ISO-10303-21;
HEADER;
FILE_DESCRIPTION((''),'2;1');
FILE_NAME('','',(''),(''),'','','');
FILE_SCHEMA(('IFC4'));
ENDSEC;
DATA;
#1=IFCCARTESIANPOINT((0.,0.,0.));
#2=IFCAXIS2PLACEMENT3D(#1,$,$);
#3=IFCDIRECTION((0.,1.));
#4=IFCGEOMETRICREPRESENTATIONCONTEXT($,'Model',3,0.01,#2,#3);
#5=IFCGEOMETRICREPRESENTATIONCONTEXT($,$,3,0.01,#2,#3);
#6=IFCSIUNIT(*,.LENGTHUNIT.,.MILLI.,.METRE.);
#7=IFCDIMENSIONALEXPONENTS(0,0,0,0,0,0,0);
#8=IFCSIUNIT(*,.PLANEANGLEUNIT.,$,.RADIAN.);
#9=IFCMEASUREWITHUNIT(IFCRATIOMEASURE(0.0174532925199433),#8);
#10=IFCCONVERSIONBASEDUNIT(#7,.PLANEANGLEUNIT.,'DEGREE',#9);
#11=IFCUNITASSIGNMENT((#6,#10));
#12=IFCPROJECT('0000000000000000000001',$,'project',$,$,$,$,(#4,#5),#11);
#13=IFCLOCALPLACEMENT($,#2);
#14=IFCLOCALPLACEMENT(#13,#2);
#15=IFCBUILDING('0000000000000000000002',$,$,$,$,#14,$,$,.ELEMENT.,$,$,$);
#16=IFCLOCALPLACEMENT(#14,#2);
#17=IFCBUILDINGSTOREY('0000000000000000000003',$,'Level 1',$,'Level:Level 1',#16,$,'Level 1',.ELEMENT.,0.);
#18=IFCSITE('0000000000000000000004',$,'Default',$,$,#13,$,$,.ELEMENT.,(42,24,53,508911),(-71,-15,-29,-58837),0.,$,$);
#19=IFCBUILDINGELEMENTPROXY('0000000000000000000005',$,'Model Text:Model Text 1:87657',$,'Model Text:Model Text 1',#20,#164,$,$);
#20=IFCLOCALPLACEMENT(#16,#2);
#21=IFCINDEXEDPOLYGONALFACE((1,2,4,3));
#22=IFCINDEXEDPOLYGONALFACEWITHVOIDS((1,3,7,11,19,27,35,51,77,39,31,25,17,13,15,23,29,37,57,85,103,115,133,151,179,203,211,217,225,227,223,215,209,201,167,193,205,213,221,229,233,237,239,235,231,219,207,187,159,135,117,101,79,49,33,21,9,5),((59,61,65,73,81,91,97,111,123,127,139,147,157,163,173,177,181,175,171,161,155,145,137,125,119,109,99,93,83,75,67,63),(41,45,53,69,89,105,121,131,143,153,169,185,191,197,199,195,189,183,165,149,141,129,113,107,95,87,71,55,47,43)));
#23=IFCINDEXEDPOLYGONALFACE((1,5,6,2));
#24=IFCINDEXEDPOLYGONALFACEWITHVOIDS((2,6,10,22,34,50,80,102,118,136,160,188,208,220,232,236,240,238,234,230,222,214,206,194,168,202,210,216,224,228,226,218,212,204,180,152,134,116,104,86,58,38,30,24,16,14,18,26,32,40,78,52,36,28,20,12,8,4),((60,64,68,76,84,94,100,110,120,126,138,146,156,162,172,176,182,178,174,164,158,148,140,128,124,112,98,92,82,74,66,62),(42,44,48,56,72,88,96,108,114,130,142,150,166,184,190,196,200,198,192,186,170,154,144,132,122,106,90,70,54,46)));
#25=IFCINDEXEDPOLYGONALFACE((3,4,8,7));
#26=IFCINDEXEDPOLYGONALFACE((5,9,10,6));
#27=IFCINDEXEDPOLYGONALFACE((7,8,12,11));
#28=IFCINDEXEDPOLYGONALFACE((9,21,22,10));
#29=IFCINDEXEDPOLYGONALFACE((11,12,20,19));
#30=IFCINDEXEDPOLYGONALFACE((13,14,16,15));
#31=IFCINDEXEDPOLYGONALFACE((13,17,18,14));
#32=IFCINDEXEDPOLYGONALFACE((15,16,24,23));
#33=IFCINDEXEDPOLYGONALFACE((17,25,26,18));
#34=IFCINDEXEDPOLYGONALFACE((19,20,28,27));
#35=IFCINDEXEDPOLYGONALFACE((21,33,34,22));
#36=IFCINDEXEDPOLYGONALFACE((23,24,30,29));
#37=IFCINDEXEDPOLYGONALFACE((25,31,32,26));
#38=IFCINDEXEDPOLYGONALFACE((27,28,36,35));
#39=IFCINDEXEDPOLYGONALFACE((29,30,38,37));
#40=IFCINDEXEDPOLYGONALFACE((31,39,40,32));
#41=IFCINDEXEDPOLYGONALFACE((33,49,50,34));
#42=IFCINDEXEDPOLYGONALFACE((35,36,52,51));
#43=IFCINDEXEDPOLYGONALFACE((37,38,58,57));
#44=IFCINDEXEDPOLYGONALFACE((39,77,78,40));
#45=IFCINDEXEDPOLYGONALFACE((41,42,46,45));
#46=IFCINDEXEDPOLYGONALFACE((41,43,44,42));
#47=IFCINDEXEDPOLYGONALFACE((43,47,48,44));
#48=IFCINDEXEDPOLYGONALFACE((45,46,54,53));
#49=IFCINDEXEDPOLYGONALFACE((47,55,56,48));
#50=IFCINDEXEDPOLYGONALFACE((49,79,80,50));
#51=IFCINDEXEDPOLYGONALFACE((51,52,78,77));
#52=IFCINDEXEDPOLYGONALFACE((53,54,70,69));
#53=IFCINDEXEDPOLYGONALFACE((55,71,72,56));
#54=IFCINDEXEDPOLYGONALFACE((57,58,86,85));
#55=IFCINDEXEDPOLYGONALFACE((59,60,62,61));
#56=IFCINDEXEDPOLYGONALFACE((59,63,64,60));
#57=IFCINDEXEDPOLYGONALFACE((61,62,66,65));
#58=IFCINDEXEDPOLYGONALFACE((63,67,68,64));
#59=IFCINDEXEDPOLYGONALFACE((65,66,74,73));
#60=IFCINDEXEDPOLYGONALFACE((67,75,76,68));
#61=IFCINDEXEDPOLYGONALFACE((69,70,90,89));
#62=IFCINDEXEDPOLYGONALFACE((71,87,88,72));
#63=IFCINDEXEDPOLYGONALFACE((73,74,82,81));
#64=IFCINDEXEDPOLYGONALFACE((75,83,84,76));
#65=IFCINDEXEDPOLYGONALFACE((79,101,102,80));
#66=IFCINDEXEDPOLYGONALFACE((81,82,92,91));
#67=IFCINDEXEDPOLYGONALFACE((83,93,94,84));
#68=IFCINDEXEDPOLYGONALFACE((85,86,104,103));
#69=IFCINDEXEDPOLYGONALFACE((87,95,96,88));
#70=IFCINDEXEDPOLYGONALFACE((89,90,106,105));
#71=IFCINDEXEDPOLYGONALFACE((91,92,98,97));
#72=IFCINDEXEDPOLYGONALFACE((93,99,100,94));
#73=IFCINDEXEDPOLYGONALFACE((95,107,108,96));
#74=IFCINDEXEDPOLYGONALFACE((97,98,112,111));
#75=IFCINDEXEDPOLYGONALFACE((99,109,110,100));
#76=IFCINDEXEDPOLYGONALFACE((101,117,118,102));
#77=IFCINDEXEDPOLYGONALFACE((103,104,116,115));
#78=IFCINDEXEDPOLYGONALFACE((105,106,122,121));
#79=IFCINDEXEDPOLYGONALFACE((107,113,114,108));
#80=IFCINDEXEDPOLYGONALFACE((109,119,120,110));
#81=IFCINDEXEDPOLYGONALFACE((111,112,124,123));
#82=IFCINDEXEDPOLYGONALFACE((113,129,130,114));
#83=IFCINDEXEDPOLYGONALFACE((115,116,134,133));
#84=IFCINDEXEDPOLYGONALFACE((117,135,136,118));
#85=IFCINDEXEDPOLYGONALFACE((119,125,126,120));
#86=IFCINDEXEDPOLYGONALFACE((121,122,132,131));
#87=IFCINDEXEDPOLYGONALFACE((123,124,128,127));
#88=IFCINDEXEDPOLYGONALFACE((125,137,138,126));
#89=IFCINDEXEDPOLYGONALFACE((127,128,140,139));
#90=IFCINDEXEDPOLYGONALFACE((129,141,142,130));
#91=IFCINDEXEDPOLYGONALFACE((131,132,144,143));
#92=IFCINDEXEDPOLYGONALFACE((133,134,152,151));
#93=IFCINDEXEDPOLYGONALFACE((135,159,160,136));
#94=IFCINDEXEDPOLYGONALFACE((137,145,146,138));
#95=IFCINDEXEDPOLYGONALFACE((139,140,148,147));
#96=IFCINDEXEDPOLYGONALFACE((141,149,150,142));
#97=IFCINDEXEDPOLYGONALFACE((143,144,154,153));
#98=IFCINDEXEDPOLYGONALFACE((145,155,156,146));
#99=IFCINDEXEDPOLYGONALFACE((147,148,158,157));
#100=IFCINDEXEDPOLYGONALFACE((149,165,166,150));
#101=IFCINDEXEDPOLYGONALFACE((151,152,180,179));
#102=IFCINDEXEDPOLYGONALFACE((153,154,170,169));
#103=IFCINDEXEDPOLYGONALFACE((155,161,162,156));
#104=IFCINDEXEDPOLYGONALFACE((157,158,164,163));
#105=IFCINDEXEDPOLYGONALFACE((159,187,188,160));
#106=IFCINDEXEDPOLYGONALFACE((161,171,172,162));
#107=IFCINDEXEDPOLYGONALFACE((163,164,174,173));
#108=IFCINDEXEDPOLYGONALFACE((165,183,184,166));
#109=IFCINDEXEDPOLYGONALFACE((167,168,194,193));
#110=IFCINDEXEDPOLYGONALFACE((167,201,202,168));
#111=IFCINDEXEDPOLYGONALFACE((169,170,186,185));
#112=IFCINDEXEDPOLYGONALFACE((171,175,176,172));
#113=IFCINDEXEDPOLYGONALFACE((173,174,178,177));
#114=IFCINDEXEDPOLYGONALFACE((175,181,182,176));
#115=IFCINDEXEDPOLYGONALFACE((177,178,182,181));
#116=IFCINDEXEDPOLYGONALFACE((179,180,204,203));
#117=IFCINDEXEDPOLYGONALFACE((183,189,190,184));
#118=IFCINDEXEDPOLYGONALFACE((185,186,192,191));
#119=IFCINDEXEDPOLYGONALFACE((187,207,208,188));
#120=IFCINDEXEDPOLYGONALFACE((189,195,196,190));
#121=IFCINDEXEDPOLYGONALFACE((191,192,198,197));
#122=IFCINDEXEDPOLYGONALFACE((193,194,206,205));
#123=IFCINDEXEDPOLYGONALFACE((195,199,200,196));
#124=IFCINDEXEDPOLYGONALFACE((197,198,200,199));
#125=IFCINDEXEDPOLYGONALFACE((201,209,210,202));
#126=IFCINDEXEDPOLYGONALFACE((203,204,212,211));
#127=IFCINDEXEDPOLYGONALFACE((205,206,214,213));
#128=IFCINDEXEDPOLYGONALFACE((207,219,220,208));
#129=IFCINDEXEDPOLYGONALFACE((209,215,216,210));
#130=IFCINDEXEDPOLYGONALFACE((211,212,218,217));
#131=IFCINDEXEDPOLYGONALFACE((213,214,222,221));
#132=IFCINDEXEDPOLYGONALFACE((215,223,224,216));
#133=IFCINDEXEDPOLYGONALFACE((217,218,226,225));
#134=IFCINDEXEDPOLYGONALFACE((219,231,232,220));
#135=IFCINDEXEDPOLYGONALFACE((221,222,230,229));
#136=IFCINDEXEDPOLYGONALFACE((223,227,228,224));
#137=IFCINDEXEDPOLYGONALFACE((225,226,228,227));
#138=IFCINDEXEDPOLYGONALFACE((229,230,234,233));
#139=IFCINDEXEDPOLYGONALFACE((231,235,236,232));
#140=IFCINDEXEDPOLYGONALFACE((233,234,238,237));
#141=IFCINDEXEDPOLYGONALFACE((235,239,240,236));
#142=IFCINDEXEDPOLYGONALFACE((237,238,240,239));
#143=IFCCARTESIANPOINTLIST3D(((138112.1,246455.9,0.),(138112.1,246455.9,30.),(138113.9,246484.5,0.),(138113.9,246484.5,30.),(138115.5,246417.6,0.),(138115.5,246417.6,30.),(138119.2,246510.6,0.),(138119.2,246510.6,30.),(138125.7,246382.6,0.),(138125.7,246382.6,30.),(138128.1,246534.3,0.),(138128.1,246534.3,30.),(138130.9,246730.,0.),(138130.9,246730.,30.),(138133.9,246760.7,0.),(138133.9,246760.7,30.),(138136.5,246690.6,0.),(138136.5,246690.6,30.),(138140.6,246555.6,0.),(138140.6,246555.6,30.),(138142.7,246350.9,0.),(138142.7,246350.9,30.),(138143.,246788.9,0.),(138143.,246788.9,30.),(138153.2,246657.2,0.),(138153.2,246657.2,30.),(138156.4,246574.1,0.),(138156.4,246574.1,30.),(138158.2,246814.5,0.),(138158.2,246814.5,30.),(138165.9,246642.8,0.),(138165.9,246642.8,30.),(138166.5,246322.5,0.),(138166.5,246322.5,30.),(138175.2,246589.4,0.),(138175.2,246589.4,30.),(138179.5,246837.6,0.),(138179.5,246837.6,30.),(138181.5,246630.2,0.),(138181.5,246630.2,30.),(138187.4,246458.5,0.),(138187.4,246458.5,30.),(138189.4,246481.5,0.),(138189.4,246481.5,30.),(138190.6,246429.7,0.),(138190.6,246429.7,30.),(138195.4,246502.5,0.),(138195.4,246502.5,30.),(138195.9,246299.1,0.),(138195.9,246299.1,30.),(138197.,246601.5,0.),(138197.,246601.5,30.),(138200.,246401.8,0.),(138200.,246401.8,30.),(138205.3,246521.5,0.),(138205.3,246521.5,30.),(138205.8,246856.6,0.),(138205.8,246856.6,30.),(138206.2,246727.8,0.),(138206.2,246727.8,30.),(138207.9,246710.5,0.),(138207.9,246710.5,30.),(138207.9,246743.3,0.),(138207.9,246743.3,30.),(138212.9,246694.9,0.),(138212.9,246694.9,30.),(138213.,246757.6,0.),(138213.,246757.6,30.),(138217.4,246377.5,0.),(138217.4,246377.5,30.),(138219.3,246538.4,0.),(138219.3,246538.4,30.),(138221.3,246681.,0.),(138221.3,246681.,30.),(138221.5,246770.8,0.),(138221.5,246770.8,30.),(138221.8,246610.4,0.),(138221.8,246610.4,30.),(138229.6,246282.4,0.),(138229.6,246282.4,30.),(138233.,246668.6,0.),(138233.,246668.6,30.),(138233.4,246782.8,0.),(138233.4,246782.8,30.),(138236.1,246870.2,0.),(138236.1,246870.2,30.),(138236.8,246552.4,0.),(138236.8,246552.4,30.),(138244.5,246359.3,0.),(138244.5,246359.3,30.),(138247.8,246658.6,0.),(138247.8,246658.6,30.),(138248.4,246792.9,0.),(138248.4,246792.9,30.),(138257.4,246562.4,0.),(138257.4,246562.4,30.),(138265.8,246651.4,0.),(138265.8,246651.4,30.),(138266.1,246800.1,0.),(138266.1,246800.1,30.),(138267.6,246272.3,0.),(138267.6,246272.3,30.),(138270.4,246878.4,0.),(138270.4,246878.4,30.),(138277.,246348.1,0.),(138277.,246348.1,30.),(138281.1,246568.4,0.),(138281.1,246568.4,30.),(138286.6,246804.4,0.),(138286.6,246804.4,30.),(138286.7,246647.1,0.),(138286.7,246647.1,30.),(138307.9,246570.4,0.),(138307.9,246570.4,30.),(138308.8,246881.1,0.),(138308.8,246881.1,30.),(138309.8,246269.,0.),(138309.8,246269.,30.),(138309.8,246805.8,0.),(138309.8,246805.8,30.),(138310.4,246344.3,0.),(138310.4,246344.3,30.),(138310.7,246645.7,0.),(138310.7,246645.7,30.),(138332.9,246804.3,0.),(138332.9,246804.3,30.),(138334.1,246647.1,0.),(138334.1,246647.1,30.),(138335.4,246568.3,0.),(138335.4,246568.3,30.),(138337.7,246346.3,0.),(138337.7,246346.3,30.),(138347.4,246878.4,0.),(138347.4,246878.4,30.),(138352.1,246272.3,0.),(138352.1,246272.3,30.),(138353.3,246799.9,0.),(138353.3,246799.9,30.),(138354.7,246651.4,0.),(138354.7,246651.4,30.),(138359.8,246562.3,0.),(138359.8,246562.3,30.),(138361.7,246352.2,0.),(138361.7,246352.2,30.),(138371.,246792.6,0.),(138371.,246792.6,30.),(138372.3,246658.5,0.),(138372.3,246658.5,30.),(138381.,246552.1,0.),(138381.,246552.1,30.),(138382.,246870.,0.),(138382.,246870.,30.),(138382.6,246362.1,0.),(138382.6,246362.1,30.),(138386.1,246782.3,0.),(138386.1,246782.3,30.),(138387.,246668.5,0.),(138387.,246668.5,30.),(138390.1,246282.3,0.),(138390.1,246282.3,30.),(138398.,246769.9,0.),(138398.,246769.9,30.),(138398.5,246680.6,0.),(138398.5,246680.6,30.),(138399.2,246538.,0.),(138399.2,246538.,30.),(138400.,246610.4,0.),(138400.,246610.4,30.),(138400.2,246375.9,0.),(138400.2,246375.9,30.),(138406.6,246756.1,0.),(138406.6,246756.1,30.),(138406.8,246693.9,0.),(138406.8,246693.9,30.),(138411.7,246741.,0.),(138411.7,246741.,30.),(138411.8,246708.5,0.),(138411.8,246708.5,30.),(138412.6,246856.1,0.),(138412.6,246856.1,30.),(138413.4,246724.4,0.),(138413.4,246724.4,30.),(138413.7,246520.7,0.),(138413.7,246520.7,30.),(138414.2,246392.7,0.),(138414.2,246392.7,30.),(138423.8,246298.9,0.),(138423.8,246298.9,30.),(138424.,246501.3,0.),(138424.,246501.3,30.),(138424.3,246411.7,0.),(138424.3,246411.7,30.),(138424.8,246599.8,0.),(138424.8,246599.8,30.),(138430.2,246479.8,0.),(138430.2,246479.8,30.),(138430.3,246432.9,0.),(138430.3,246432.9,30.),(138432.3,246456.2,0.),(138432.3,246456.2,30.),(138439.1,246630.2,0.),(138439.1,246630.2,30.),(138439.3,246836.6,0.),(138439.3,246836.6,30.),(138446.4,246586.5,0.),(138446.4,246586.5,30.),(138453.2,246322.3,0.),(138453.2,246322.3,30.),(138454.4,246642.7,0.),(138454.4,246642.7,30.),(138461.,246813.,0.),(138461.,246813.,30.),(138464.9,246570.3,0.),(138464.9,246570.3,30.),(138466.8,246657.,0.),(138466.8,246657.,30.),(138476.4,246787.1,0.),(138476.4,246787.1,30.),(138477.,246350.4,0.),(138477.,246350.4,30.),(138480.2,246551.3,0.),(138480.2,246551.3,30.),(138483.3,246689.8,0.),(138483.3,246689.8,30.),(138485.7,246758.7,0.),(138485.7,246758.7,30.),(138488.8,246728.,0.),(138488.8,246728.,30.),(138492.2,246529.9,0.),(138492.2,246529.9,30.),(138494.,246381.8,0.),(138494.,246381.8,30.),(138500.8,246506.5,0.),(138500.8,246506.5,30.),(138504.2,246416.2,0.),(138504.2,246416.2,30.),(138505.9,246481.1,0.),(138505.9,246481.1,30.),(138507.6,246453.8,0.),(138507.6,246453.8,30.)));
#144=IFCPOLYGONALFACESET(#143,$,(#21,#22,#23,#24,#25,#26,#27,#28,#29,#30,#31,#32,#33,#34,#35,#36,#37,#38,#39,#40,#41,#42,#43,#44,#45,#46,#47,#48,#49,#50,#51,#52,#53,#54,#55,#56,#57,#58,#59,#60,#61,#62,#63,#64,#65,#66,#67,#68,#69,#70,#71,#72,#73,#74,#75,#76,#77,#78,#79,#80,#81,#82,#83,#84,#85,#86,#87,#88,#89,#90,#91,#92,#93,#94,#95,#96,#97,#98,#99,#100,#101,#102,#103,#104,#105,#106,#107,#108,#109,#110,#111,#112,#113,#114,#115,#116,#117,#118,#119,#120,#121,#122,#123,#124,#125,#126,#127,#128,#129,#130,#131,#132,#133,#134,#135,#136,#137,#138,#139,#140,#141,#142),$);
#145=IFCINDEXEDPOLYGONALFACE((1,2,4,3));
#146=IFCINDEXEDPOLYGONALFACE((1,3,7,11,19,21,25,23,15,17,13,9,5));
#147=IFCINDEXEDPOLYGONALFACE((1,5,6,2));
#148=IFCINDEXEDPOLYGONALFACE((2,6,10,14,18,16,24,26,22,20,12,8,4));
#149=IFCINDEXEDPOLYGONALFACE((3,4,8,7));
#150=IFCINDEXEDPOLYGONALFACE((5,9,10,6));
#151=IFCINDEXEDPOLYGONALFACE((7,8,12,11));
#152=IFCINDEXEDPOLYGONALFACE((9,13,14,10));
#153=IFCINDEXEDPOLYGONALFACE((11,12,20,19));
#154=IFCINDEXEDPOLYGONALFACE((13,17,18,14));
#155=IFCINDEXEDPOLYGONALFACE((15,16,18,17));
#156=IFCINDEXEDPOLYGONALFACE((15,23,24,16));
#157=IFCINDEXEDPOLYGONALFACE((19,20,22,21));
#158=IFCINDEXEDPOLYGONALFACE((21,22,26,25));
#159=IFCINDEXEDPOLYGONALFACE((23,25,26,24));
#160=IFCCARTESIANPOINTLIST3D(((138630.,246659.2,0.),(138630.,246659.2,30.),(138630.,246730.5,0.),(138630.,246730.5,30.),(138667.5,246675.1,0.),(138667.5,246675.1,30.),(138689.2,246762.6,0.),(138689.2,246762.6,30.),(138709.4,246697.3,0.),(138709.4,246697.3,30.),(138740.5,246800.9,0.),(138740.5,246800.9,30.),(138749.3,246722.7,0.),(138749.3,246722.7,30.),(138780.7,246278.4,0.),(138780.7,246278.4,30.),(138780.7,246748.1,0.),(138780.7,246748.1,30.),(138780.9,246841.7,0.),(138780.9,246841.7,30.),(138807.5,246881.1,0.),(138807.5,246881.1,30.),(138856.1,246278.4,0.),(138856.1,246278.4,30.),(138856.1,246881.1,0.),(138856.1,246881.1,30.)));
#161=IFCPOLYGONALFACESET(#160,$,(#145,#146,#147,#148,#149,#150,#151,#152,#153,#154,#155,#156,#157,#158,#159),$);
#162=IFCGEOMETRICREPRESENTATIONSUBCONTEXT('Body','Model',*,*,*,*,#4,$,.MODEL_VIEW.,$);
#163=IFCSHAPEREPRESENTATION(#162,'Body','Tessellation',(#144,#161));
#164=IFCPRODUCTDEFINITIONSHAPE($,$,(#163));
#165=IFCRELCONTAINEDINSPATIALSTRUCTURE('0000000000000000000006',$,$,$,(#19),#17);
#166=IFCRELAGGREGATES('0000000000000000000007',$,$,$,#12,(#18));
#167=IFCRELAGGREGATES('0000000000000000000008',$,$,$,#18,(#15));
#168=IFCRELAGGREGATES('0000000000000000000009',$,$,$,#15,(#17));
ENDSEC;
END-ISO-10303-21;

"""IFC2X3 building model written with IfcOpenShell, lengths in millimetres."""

from ifc_helpers import new_model, entity, si_unit, converted_unit, direction, frame, origin, place, context, subcontext, project, spatial, polyline, outline, extrude, element, save


model = new_model("IFC2X3")

# Units and contexts
model_context = context("Model", 3, precision=0.01, world=origin(), true_north=direction((0.0, 1.0)))
context_of_model = context(None, 3, precision=0.01, world=origin(), true_north=direction((0.0, 1.0)))
body_context = subcontext(model_context, "Body", "Model", "MODEL_VIEW")
ifc_project = project(units=[si_unit("LENGTHUNIT", "METRE", prefix="MILLI"), converted_unit("PLANEANGLEUNIT", "DEGREE", entity("IfcRatioMeasure", 0.0174532925199433), si_unit("PLANEANGLEUNIT", "RADIAN"), dimensions=[0, 0, 0, 0, 0, 0, 0])], contexts=[model_context, context_of_model])

# Site, building, storey
site_placement = place(None, origin())
site = spatial("IfcSite", under=ifc_project, at=site_placement, Name="Default", CompositionType="ELEMENT", RefLatitude=(42, 24, 53, 508911), RefLongitude=(-71, -15, -29, -58837), RefElevation=0.0)
building_placement = place(site_placement, origin())
building = spatial("IfcBuilding", under=site, at=building_placement, CompositionType="ELEMENT")
storey_placement = place(building_placement, origin())
storey = spatial("IfcBuildingStorey", under=building, at=storey_placement, Name="Level 1", ObjectType="Level:Level 1", LongName="Level 1", CompositionType="ELEMENT", Elevation=0.0)

# Building element proxy
proxy_1_placement = place(storey_placement, origin())
element("IfcBuildingElementProxy", 1, at=proxy_1_placement, inside=storey, Name="Model Text:Model Text 1:87657", ObjectType="Model Text:Model Text 1", context=body_context, shape_type="SweptSolid", body=[
    extrude(outline(polyline([(74.3, -53.8), (100.6, -53.8), (125.3, -49.8), (148.1, -41.8), (169.2, -29.7), (188.1, -13.8), (204.5, 5.5), (218.4, 28.3), (229.7, 54.7), (239.4, 91.9), (241.6, 128.3), (236.2, 163.8), (223.4, 198.6), (203.6, 230.5), (177.5, 257.6), (145.1, 279.9), (106.4, 297.2), (65.5, 308.4), (26.4, 311.7), (-11.0, 307.4), (-46.5, 295.4), (-78.4, 276.8), (-105.0, 253.1), (-126.2, 224.1), (-142.0, 189.8), (-149.6, 163.5), (-153.3, 137.9), (-153.1, 113.0), (-149.0, 88.8), (-141.0, 65.8), (-129.1, 44.3), (-113.3, 24.5), (-93.5, 6.2), (-137.0, 0.7), (-155.5, -5.9), (-172.0, -15.2), (-198.6, -40.6), (-216.7, -74.6), (-224.1, -104.7), (-225.0, -134.5), (-219.1, -164.1), (-206.7, -193.5), (-188.1, -220.9), (-164.0, -244.3), (-134.2, -263.9), (-98.8, -279.5), (-61.8, -289.8), (-26.7, -293.7), (6.5, -291.1), (37.6, -282.0), (65.4, -267.5), (88.3, -248.5), (106.4, -225.0), (119.6, -197.1), (127.6, -158.1), (123.1, -121.0), (116.1, -103.3), (105.6, -86.1), (74.3, -53.8)]), holes=[polyline([(49.4, -169.7), (42.6, -183.7), (33.0, -195.4), (20.5, -205.0), (5.3, -212.3), (-12.2, -216.7), (-31.3, -217.5), (-52.0, -214.7), (-74.4, -208.2), (-95.6, -199.0), (-113.4, -188.0), (-127.6, -175.1), (-138.3, -160.4), (-145.4, -144.7), (-148.8, -128.8), (-148.5, -112.8), (-144.5, -96.7), (-137.6, -82.3), (-128.0, -70.2), (-115.7, -60.4), (-100.8, -52.9), (-83.6, -48.5), (-64.6, -47.7), (-43.8, -50.6), (-21.3, -57.2), (0.8, -66.6), (19.1, -77.7), (33.6, -90.5), (44.2, -105.0), (51.0, -120.5), (54.2, -136.4), (53.7, -152.8), (49.4, -169.7)]), polyline([(157.9, 77.5), (148.2, 56.6), (135.5, 38.8), (119.8, 24.3), (100.9, 13.0), (79.8, 5.8), (57.0, 3.3), (32.7, 5.7), (6.7, 12.8), (-18.5, 24.0), (-39.4, 37.9), (-56.0, 54.6), (-68.3, 74.1), (-76.1, 95.2), (-79.3, 116.9), (-77.9, 139.3), (-71.9, 162.2), (-62.2, 183.5), (-49.4, 201.4), (-33.6, 215.9), (-14.7, 227.0), (6.6, 234.1), (29.5, 236.4), (54.2, 233.8), (80.5, 226.5), (110.7, 211.7), (137.5, 190.2), (156.9, 164.0), (165.1, 135.2), (164.6, 105.7), (157.9, 77.5)])]), frame((138309.9, 246584.7, 0.0), z_axis=(0.0, 0.0, 1.0), x_axis=(-0.941552, -0.336867, 0.0)), (0.0, 0.0, 1.0), 30.0),
    extrude(outline(polyline([(-410.6, -111.6), (192.1, -111.6), (192.1, -63.1), (152.7, -36.4), (111.9, 4.0), (73.6, 55.2), (41.4, 114.4), (-29.8, 114.4), (-13.9, 77.0), (8.3, 35.1), (33.7, -4.8), (59.1, -36.3), (-410.6, -36.3), (-410.6, -111.6)])), frame((138744.5, 246689.0, 0.0), z_axis=(0.0, 0.0, 1.0), x_axis=(0.0, 1.0, 0.0)), (0.0, 0.0, 1.0), 30.0),
])

save(model, "model.ifc")
